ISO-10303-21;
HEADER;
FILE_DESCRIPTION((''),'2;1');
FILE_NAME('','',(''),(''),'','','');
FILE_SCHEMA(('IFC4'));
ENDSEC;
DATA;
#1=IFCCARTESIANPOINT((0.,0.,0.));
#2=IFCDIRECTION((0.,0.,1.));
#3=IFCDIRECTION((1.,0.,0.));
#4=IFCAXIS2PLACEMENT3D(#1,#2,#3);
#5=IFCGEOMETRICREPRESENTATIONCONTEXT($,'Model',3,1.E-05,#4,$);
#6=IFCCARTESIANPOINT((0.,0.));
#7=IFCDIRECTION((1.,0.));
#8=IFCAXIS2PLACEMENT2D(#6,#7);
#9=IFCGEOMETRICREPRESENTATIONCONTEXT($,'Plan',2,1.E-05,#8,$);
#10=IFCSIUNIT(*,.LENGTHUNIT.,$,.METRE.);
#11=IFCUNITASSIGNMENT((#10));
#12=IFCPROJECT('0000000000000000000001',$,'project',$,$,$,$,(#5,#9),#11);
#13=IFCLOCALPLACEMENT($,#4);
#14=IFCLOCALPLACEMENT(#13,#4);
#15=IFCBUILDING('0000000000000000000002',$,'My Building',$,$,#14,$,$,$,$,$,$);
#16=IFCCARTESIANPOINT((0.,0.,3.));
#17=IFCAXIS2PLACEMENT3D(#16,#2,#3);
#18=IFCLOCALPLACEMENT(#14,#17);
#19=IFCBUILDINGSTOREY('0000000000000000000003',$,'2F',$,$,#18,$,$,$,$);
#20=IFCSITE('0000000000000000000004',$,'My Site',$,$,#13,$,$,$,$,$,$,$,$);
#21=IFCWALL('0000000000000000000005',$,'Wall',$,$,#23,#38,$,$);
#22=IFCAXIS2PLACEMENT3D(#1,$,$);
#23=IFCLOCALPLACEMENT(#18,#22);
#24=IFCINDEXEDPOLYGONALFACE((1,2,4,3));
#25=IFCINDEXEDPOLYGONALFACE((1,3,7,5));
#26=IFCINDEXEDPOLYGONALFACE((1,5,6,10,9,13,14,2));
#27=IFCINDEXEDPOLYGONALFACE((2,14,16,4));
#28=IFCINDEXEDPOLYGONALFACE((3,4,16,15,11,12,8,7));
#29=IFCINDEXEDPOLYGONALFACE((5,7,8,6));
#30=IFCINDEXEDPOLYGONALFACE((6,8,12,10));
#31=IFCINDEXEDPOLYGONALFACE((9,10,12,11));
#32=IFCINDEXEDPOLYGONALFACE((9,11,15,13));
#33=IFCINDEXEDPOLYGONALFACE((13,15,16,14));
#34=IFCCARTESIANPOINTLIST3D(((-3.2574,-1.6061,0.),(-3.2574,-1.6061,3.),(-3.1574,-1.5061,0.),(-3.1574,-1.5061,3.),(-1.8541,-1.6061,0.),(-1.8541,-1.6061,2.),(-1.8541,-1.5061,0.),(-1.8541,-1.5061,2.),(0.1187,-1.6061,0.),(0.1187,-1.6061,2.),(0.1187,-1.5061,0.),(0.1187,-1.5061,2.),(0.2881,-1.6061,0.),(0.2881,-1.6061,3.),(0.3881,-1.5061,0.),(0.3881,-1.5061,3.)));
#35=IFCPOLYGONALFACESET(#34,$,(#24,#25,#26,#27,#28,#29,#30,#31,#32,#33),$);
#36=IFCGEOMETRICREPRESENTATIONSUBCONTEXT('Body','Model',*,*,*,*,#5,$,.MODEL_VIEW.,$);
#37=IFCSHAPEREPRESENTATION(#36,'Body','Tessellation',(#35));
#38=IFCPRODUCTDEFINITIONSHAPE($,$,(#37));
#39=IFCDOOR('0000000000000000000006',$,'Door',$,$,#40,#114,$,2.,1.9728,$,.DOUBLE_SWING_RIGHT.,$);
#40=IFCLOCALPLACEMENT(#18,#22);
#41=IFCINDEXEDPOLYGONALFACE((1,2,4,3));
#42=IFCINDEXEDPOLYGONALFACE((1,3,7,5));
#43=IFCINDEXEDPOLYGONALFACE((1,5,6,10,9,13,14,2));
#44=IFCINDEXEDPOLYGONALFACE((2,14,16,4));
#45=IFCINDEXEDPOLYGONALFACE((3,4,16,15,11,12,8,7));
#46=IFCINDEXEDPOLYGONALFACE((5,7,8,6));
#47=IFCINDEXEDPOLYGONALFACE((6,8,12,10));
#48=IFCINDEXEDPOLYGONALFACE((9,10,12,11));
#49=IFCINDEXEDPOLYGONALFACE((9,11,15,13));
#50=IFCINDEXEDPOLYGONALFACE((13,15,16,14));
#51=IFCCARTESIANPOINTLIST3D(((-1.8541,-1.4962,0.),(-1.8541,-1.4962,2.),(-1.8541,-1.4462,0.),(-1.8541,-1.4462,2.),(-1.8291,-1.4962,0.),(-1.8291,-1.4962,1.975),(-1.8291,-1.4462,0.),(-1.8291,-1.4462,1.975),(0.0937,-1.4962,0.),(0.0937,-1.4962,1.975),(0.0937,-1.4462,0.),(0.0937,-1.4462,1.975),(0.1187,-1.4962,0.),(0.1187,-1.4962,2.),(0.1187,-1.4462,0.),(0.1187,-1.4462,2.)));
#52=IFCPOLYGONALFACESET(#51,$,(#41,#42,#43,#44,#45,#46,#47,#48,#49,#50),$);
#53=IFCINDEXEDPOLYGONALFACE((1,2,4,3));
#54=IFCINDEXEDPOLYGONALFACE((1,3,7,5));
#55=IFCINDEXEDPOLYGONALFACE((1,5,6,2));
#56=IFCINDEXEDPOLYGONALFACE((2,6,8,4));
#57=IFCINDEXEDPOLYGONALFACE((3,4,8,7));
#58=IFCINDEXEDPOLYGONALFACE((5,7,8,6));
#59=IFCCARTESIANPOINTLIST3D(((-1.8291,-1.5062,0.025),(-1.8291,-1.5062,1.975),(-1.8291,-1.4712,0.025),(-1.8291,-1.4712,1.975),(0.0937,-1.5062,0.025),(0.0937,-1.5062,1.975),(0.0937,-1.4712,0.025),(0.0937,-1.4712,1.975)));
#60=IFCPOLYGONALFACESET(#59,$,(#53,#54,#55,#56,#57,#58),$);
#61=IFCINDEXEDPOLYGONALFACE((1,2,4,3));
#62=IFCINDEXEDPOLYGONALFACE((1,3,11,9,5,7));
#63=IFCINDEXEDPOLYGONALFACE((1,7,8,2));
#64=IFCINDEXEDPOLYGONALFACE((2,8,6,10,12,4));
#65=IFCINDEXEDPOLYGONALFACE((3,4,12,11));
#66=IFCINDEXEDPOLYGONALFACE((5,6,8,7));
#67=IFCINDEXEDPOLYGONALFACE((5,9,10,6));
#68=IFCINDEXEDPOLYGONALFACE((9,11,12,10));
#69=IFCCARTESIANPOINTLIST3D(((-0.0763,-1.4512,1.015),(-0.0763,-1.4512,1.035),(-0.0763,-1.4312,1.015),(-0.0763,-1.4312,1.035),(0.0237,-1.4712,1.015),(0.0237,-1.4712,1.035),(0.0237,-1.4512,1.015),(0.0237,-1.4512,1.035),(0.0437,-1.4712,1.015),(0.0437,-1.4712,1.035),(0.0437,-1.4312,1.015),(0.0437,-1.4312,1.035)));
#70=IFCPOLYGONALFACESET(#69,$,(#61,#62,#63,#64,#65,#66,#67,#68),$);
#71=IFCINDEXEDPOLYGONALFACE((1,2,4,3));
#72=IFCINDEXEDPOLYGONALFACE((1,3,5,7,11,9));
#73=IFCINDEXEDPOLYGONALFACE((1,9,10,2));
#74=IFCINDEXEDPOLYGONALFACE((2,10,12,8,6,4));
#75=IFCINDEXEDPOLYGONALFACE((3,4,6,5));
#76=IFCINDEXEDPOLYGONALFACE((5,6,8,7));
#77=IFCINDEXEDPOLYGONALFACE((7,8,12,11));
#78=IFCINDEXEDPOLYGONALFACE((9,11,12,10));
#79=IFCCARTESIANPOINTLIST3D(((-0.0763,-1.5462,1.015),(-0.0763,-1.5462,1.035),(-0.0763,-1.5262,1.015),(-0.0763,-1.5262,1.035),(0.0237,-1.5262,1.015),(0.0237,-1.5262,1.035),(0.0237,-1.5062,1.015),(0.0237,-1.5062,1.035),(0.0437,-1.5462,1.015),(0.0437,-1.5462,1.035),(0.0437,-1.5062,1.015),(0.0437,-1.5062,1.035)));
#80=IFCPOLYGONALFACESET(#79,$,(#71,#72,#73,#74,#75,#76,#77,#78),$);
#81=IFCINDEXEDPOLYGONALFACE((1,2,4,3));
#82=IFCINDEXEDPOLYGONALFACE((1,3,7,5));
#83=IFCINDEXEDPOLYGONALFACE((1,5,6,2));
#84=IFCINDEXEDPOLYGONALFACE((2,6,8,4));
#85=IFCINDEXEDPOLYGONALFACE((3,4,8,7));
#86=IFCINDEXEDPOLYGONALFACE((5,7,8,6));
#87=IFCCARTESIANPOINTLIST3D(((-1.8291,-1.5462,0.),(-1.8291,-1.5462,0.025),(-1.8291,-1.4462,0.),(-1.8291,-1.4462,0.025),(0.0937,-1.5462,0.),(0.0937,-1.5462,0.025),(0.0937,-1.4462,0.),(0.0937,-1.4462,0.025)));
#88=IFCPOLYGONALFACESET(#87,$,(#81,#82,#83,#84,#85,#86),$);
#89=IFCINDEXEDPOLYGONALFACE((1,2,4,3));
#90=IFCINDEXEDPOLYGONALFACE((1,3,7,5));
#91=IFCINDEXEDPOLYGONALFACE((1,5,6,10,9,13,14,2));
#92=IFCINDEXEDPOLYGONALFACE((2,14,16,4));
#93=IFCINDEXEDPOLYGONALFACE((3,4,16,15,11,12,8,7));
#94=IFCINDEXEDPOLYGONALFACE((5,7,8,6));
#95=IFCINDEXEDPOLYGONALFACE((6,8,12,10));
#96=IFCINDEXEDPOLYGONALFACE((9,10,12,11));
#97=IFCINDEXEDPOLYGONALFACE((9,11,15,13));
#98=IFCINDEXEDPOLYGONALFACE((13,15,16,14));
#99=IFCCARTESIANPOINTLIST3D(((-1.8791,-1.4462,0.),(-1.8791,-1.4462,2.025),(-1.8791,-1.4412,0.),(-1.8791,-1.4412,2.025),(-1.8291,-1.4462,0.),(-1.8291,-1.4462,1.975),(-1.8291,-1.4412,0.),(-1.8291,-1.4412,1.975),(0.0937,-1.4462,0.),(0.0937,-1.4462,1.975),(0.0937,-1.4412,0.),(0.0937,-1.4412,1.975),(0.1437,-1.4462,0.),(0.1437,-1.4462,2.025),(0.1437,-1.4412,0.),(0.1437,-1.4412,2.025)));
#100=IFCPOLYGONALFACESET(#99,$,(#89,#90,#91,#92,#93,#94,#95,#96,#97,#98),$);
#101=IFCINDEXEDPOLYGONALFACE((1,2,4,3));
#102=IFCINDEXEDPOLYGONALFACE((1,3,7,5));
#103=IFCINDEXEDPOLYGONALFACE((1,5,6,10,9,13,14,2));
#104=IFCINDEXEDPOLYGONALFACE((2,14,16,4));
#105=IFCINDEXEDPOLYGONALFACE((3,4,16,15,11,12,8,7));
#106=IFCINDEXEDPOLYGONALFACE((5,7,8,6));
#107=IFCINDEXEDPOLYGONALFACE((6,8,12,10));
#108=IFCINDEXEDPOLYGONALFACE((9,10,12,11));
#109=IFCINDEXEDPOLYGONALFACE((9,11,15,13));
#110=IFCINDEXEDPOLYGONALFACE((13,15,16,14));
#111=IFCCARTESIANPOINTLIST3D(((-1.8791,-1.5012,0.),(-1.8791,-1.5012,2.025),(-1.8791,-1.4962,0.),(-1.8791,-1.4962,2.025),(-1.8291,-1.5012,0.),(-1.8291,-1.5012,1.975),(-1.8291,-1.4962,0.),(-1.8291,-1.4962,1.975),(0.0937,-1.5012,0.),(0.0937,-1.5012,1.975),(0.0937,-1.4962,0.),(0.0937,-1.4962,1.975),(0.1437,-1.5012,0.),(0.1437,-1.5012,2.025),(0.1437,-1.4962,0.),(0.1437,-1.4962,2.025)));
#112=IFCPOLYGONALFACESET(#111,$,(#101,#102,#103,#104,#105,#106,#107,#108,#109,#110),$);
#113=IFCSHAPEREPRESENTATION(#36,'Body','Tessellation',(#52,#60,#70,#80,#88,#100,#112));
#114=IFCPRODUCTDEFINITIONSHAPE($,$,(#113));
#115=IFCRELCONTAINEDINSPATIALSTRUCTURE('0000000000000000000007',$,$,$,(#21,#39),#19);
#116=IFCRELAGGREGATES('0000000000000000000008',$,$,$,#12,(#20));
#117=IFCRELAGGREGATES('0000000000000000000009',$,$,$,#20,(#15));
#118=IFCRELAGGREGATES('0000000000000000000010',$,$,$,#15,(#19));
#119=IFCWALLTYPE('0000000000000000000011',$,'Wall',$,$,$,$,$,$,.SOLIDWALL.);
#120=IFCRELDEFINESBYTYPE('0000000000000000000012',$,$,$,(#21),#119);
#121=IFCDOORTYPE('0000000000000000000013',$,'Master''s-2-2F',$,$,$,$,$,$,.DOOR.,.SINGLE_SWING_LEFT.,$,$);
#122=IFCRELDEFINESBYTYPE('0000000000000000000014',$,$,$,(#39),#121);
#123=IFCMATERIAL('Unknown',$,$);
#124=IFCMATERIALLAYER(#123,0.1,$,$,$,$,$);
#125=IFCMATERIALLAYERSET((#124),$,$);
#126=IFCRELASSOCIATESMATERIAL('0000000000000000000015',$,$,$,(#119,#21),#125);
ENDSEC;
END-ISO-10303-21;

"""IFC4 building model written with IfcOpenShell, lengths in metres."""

from ifc_helpers import new_model, entity, si_unit, frame, origin_with_axes, origin_2d_with_axis, place, context, subcontext, project, spatial, line, indexed_curve, outline, extrude, shape, source, transform, mapped, material, layer, layer_set, layer_usage, type_object, type_shapes, element, fill, save


model = new_model("IFC4")

# Units and contexts
model_context = context("Model", 3, precision=1e-05, world=origin_with_axes())
plan_context = context("Plan", 2, precision=1e-05, world=origin_2d_with_axis())
body_context_1 = subcontext(model_context, "Body", "Model", "MODEL_VIEW")
body_context_2 = subcontext(plan_context, "Body", "Plan", "PLAN_VIEW")
ifc_project = project(units=[si_unit("LENGTHUNIT", "METRE")], contexts=[model_context, plan_context])

# Site, building, storey
site_placement = place(None, origin_with_axes())
site = spatial("IfcSite", under=ifc_project, at=site_placement, Name="My Site")
building_placement = place(site_placement, origin_with_axes())
building = spatial("IfcBuilding", under=site, at=building_placement, Name="My Building")
storey_placement = place(building_placement, frame((0.0, 0.0, 3.0), z_axis=(0.0, 0.0, 1.0), x_axis=(1.0, 0.0, 0.0)))
storey = spatial("IfcBuildingStorey", under=building, at=storey_placement, Name="2F")

# Shared definitions
ifc_material = material(Name="Unknown")

# Shared definitions
ifc_layer_1 = layer(ifc_material, 0.1)
ifc_layer_set_1 = layer_set([ifc_layer_1])
wall_type = type_object("IfcWallType", Name="Wall", PredefinedType="SOLIDWALL", material=ifc_layer_set_1)

# Wall, opening, door
ifc_layer_usage_1 = layer_usage(ifc_layer_set_1, "AXIS2", "POSITIVE", 0.0)
wall_1_placement = place(storey_placement, frame((-3.2574, -1.6061, 0.0), z_axis=(0.0, 0.0, 1.0), x_axis=(1.0, 0.0, 0.0)))
wall_1 = element("IfcWall", 1, at=wall_1_placement, inside=storey, type_object=wall_type, material=ifc_layer_usage_1, Name="Wall", context=body_context_1, shape_type="SweptSolid", body=[
    extrude(outline(indexed_curve([(0.0, 0.0), (0.1, 0.1), (3.6455, 0.1), (3.5455, 0.0)], segments=[line(1, 2, 3, 4, 1)])), origin_with_axes(), (0.0, 0.0, 1.0), 3.0),
])
shared_shape_1 = source(origin_with_axes(), body_context_1, "Body", "SweptSolid", [
    extrude(outline(indexed_curve([(0.0, 0.0), (1.9728, 0.0), (1.9728, 2.0), (0.0, 2.0)], segments=[line(1, 2, 3, 4, 1)])), frame((0.0, -0.6, 0.0), z_axis=(0.0, -1.0, 0.0), x_axis=(1.0, 0.0, 0.0)), (0.0, 0.0, -1.0), 1.2),
])
opening_1_placement = place(wall_1_placement, frame((3.376, 0.16, 0.0), z_axis=(0.0, 0.0, 1.0), x_axis=(-1.0, 0.000003, 0.0)))
opening_1 = element("IfcOpeningElement", 2, at=opening_1_placement, cuts=wall_1, PredefinedType="OPENING", context=body_context_1, shape_type="MappedRepresentation", body=[
    mapped(shared_shape_1, transform((0.0, 0.0, 0.0), x_axis=(1.0, 0.0, 0.0), y_axis=(0.0, 1.0, 0.0), z_axis=(0.0, 0.0, 1.0), scale=1.0)),
])
door_type_1 = type_object("IfcDoorType", Name="Master's-2-2F", OperationType="SINGLE_SWING_LEFT", PredefinedType="DOOR")
shared_shape_2 = source(origin_with_axes(), body_context_1, "Body", "SweptSolid", [
    extrude(outline(indexed_curve([(0.0, 0.0), (0.0, 2.0), (1.9728, 2.0), (1.9728, 0.0), (1.9478, 0.0), (1.9478, 1.975), (0.025, 1.975), (0.025, 0.0)], segments=[line(1, 2, 3, 4, 5, 6, 7, 8, 1)])), frame((0.0, 0.0, 0.0), z_axis=(0.0, -1.0, 0.0), x_axis=(1.0, 0.0, 0.0)), (0.0, 0.0, -1.0), 0.05),
    extrude(outline(indexed_curve([(0.0, 0.0), (1.9228, 0.0), (1.9228, 0.035), (0.0, 0.035)], segments=[line(1, 2, 3, 4, 1)])), frame((0.025, 0.025, 0.025), z_axis=(0.0, 0.0, 1.0), x_axis=(1.0, 0.0, 0.0)), (0.0, 0.0, 1.0), 1.95),
    extrude(outline(indexed_curve([(0.0, 0.0), (0.0, -0.04), (0.12, -0.04), (0.12, -0.02), (0.02, -0.02), (0.02, 0.0)], segments=[line(1, 2, 3, 4, 5, 6, 1)])), frame((0.075, 0.025, 1.015), z_axis=(0.0, 0.0, 1.0), x_axis=(1.0, 0.0, 0.0)), (0.0, 0.0, 1.0), 0.02),
    extrude(outline(indexed_curve([(0.0, 0.0), (0.0, 0.04), (0.12, 0.04), (0.12, 0.02), (0.02, 0.02), (0.02, 0.0)], segments=[line(1, 2, 3, 4, 5, 6, 1)])), frame((0.075, 0.06, 1.015), z_axis=(0.0, 0.0, 1.0), x_axis=(1.0, 0.0, 0.0)), (0.0, 0.0, 1.0), 0.02),
    extrude(outline(indexed_curve([(0.0, 0.0), (1.9228, 0.0), (1.9228, 0.1), (0.0, 0.1)], segments=[line(1, 2, 3, 4, 1)])), frame((0.025, 0.0, 0.0), z_axis=(0.0, 0.0, 1.0), x_axis=(1.0, 0.0, 0.0)), (0.0, 0.0, 1.0), 0.025),
    extrude(outline(indexed_curve([(0.0, 0.0), (0.0, 2.025), (2.0228, 2.025), (2.0228, 0.0), (1.9728, 0.0), (1.9728, 1.975), (0.05, 1.975), (0.05, 0.0)], segments=[line(1, 2, 3, 4, 5, 6, 7, 8, 1)])), frame((-0.025, -0.005, 0.0), z_axis=(0.0, -1.0, 0.0), x_axis=(1.0, 0.0, 0.0)), (0.0, 0.0, -1.0), 0.005),
    extrude(outline(indexed_curve([(0.0, 0.0), (0.0, 2.025), (2.0228, 2.025), (2.0228, 0.0), (1.9728, 0.0), (1.9728, 1.975), (0.05, 1.975), (0.05, 0.0)], segments=[line(1, 2, 3, 4, 5, 6, 7, 8, 1)])), frame((-0.025, 0.05, 0.0), z_axis=(0.0, -1.0, 0.0), x_axis=(1.0, 0.0, 0.0)), (0.0, 0.0, -1.0), 0.005),
])
shared_shape_3 = source(origin_with_axes(), body_context_2, "Body", "Curve2D", [
    entity("IfcIndexedPolyCurve", entity("IfcCartesianPointList2D", [[0.0, 0.0], [0.025, 0.0], [0.025, 0.05], [0.0, 0.05]]), [entity("IfcLineIndex", [1, 2, 3, 4, 1])]),
    entity("IfcIndexedPolyCurve", entity("IfcCartesianPointList2D", [[1.9728, 0.0], [1.9478, 0.0], [1.9478, 0.05], [1.9728, 0.05]]), [entity("IfcLineIndex", [1, 2, 3, 4, 1])]),
    entity("IfcIndexedPolyCurve", entity("IfcCartesianPointList2D", [[1.9478, 0.05], [1.9478, -1.8728], [1.9128, -1.8728]])),
    entity("IfcTrimmedCurve", entity("IfcEllipse", entity("IfcAxis2Placement2D", entity("IfcCartesianPoint", [1.9128, 0.05]), entity("IfcDirection", [1.0, 0.0])), 1.8878, 1.9228), [entity("IfcCartesianPoint", [1.9128, 1.9728])], [entity("IfcCartesianPoint", [1.9128, -1.8728])], True, "CARTESIAN"),
    entity("IfcIndexedPolyCurve", entity("IfcCartesianPointList2D", [[1.9478, 0.05], [1.9128, 0.05], [1.9128, 1.9728], [1.9478, 1.9728]]), [entity("IfcLineIndex", [1, 2, 3, 4, 1])]),
])
type_shapes(door_type_1, [shared_shape_2, shared_shape_3])
door_1_placement = place(opening_1_placement, frame((0.0, 0.0, 0.0), z_axis=(0.0, 0.0, 1.0), x_axis=(1.0, 0.0, 0.0)))
door_1 = element("IfcDoor", 3, at=door_1_placement, inside=storey, type_object=door_type_1, Name="Door", OperationType="DOUBLE_SWING_RIGHT", OverallHeight=2.0, OverallWidth=1.9728, shapes=[
    shape(body_context_1, "Body", "MappedRepresentation", [mapped(shared_shape_2, transform((0.0, 0.0, 0.0), x_axis=(1.0, 0.0, 0.0), y_axis=(0.0, 1.0, 0.0), z_axis=(0.0, 0.0, 1.0), scale=1.0))]),
    shape(body_context_2, "Body", "MappedRepresentation", [mapped(shared_shape_3, transform((0.0, 0.0, 0.0), x_axis=(1.0, 0.0, 0.0), y_axis=(0.0, 1.0, 0.0), z_axis=(0.0, 0.0, 1.0), scale=1.0))]),
])
fill(opening_1, door_1)

save(model, "model.ifc")
